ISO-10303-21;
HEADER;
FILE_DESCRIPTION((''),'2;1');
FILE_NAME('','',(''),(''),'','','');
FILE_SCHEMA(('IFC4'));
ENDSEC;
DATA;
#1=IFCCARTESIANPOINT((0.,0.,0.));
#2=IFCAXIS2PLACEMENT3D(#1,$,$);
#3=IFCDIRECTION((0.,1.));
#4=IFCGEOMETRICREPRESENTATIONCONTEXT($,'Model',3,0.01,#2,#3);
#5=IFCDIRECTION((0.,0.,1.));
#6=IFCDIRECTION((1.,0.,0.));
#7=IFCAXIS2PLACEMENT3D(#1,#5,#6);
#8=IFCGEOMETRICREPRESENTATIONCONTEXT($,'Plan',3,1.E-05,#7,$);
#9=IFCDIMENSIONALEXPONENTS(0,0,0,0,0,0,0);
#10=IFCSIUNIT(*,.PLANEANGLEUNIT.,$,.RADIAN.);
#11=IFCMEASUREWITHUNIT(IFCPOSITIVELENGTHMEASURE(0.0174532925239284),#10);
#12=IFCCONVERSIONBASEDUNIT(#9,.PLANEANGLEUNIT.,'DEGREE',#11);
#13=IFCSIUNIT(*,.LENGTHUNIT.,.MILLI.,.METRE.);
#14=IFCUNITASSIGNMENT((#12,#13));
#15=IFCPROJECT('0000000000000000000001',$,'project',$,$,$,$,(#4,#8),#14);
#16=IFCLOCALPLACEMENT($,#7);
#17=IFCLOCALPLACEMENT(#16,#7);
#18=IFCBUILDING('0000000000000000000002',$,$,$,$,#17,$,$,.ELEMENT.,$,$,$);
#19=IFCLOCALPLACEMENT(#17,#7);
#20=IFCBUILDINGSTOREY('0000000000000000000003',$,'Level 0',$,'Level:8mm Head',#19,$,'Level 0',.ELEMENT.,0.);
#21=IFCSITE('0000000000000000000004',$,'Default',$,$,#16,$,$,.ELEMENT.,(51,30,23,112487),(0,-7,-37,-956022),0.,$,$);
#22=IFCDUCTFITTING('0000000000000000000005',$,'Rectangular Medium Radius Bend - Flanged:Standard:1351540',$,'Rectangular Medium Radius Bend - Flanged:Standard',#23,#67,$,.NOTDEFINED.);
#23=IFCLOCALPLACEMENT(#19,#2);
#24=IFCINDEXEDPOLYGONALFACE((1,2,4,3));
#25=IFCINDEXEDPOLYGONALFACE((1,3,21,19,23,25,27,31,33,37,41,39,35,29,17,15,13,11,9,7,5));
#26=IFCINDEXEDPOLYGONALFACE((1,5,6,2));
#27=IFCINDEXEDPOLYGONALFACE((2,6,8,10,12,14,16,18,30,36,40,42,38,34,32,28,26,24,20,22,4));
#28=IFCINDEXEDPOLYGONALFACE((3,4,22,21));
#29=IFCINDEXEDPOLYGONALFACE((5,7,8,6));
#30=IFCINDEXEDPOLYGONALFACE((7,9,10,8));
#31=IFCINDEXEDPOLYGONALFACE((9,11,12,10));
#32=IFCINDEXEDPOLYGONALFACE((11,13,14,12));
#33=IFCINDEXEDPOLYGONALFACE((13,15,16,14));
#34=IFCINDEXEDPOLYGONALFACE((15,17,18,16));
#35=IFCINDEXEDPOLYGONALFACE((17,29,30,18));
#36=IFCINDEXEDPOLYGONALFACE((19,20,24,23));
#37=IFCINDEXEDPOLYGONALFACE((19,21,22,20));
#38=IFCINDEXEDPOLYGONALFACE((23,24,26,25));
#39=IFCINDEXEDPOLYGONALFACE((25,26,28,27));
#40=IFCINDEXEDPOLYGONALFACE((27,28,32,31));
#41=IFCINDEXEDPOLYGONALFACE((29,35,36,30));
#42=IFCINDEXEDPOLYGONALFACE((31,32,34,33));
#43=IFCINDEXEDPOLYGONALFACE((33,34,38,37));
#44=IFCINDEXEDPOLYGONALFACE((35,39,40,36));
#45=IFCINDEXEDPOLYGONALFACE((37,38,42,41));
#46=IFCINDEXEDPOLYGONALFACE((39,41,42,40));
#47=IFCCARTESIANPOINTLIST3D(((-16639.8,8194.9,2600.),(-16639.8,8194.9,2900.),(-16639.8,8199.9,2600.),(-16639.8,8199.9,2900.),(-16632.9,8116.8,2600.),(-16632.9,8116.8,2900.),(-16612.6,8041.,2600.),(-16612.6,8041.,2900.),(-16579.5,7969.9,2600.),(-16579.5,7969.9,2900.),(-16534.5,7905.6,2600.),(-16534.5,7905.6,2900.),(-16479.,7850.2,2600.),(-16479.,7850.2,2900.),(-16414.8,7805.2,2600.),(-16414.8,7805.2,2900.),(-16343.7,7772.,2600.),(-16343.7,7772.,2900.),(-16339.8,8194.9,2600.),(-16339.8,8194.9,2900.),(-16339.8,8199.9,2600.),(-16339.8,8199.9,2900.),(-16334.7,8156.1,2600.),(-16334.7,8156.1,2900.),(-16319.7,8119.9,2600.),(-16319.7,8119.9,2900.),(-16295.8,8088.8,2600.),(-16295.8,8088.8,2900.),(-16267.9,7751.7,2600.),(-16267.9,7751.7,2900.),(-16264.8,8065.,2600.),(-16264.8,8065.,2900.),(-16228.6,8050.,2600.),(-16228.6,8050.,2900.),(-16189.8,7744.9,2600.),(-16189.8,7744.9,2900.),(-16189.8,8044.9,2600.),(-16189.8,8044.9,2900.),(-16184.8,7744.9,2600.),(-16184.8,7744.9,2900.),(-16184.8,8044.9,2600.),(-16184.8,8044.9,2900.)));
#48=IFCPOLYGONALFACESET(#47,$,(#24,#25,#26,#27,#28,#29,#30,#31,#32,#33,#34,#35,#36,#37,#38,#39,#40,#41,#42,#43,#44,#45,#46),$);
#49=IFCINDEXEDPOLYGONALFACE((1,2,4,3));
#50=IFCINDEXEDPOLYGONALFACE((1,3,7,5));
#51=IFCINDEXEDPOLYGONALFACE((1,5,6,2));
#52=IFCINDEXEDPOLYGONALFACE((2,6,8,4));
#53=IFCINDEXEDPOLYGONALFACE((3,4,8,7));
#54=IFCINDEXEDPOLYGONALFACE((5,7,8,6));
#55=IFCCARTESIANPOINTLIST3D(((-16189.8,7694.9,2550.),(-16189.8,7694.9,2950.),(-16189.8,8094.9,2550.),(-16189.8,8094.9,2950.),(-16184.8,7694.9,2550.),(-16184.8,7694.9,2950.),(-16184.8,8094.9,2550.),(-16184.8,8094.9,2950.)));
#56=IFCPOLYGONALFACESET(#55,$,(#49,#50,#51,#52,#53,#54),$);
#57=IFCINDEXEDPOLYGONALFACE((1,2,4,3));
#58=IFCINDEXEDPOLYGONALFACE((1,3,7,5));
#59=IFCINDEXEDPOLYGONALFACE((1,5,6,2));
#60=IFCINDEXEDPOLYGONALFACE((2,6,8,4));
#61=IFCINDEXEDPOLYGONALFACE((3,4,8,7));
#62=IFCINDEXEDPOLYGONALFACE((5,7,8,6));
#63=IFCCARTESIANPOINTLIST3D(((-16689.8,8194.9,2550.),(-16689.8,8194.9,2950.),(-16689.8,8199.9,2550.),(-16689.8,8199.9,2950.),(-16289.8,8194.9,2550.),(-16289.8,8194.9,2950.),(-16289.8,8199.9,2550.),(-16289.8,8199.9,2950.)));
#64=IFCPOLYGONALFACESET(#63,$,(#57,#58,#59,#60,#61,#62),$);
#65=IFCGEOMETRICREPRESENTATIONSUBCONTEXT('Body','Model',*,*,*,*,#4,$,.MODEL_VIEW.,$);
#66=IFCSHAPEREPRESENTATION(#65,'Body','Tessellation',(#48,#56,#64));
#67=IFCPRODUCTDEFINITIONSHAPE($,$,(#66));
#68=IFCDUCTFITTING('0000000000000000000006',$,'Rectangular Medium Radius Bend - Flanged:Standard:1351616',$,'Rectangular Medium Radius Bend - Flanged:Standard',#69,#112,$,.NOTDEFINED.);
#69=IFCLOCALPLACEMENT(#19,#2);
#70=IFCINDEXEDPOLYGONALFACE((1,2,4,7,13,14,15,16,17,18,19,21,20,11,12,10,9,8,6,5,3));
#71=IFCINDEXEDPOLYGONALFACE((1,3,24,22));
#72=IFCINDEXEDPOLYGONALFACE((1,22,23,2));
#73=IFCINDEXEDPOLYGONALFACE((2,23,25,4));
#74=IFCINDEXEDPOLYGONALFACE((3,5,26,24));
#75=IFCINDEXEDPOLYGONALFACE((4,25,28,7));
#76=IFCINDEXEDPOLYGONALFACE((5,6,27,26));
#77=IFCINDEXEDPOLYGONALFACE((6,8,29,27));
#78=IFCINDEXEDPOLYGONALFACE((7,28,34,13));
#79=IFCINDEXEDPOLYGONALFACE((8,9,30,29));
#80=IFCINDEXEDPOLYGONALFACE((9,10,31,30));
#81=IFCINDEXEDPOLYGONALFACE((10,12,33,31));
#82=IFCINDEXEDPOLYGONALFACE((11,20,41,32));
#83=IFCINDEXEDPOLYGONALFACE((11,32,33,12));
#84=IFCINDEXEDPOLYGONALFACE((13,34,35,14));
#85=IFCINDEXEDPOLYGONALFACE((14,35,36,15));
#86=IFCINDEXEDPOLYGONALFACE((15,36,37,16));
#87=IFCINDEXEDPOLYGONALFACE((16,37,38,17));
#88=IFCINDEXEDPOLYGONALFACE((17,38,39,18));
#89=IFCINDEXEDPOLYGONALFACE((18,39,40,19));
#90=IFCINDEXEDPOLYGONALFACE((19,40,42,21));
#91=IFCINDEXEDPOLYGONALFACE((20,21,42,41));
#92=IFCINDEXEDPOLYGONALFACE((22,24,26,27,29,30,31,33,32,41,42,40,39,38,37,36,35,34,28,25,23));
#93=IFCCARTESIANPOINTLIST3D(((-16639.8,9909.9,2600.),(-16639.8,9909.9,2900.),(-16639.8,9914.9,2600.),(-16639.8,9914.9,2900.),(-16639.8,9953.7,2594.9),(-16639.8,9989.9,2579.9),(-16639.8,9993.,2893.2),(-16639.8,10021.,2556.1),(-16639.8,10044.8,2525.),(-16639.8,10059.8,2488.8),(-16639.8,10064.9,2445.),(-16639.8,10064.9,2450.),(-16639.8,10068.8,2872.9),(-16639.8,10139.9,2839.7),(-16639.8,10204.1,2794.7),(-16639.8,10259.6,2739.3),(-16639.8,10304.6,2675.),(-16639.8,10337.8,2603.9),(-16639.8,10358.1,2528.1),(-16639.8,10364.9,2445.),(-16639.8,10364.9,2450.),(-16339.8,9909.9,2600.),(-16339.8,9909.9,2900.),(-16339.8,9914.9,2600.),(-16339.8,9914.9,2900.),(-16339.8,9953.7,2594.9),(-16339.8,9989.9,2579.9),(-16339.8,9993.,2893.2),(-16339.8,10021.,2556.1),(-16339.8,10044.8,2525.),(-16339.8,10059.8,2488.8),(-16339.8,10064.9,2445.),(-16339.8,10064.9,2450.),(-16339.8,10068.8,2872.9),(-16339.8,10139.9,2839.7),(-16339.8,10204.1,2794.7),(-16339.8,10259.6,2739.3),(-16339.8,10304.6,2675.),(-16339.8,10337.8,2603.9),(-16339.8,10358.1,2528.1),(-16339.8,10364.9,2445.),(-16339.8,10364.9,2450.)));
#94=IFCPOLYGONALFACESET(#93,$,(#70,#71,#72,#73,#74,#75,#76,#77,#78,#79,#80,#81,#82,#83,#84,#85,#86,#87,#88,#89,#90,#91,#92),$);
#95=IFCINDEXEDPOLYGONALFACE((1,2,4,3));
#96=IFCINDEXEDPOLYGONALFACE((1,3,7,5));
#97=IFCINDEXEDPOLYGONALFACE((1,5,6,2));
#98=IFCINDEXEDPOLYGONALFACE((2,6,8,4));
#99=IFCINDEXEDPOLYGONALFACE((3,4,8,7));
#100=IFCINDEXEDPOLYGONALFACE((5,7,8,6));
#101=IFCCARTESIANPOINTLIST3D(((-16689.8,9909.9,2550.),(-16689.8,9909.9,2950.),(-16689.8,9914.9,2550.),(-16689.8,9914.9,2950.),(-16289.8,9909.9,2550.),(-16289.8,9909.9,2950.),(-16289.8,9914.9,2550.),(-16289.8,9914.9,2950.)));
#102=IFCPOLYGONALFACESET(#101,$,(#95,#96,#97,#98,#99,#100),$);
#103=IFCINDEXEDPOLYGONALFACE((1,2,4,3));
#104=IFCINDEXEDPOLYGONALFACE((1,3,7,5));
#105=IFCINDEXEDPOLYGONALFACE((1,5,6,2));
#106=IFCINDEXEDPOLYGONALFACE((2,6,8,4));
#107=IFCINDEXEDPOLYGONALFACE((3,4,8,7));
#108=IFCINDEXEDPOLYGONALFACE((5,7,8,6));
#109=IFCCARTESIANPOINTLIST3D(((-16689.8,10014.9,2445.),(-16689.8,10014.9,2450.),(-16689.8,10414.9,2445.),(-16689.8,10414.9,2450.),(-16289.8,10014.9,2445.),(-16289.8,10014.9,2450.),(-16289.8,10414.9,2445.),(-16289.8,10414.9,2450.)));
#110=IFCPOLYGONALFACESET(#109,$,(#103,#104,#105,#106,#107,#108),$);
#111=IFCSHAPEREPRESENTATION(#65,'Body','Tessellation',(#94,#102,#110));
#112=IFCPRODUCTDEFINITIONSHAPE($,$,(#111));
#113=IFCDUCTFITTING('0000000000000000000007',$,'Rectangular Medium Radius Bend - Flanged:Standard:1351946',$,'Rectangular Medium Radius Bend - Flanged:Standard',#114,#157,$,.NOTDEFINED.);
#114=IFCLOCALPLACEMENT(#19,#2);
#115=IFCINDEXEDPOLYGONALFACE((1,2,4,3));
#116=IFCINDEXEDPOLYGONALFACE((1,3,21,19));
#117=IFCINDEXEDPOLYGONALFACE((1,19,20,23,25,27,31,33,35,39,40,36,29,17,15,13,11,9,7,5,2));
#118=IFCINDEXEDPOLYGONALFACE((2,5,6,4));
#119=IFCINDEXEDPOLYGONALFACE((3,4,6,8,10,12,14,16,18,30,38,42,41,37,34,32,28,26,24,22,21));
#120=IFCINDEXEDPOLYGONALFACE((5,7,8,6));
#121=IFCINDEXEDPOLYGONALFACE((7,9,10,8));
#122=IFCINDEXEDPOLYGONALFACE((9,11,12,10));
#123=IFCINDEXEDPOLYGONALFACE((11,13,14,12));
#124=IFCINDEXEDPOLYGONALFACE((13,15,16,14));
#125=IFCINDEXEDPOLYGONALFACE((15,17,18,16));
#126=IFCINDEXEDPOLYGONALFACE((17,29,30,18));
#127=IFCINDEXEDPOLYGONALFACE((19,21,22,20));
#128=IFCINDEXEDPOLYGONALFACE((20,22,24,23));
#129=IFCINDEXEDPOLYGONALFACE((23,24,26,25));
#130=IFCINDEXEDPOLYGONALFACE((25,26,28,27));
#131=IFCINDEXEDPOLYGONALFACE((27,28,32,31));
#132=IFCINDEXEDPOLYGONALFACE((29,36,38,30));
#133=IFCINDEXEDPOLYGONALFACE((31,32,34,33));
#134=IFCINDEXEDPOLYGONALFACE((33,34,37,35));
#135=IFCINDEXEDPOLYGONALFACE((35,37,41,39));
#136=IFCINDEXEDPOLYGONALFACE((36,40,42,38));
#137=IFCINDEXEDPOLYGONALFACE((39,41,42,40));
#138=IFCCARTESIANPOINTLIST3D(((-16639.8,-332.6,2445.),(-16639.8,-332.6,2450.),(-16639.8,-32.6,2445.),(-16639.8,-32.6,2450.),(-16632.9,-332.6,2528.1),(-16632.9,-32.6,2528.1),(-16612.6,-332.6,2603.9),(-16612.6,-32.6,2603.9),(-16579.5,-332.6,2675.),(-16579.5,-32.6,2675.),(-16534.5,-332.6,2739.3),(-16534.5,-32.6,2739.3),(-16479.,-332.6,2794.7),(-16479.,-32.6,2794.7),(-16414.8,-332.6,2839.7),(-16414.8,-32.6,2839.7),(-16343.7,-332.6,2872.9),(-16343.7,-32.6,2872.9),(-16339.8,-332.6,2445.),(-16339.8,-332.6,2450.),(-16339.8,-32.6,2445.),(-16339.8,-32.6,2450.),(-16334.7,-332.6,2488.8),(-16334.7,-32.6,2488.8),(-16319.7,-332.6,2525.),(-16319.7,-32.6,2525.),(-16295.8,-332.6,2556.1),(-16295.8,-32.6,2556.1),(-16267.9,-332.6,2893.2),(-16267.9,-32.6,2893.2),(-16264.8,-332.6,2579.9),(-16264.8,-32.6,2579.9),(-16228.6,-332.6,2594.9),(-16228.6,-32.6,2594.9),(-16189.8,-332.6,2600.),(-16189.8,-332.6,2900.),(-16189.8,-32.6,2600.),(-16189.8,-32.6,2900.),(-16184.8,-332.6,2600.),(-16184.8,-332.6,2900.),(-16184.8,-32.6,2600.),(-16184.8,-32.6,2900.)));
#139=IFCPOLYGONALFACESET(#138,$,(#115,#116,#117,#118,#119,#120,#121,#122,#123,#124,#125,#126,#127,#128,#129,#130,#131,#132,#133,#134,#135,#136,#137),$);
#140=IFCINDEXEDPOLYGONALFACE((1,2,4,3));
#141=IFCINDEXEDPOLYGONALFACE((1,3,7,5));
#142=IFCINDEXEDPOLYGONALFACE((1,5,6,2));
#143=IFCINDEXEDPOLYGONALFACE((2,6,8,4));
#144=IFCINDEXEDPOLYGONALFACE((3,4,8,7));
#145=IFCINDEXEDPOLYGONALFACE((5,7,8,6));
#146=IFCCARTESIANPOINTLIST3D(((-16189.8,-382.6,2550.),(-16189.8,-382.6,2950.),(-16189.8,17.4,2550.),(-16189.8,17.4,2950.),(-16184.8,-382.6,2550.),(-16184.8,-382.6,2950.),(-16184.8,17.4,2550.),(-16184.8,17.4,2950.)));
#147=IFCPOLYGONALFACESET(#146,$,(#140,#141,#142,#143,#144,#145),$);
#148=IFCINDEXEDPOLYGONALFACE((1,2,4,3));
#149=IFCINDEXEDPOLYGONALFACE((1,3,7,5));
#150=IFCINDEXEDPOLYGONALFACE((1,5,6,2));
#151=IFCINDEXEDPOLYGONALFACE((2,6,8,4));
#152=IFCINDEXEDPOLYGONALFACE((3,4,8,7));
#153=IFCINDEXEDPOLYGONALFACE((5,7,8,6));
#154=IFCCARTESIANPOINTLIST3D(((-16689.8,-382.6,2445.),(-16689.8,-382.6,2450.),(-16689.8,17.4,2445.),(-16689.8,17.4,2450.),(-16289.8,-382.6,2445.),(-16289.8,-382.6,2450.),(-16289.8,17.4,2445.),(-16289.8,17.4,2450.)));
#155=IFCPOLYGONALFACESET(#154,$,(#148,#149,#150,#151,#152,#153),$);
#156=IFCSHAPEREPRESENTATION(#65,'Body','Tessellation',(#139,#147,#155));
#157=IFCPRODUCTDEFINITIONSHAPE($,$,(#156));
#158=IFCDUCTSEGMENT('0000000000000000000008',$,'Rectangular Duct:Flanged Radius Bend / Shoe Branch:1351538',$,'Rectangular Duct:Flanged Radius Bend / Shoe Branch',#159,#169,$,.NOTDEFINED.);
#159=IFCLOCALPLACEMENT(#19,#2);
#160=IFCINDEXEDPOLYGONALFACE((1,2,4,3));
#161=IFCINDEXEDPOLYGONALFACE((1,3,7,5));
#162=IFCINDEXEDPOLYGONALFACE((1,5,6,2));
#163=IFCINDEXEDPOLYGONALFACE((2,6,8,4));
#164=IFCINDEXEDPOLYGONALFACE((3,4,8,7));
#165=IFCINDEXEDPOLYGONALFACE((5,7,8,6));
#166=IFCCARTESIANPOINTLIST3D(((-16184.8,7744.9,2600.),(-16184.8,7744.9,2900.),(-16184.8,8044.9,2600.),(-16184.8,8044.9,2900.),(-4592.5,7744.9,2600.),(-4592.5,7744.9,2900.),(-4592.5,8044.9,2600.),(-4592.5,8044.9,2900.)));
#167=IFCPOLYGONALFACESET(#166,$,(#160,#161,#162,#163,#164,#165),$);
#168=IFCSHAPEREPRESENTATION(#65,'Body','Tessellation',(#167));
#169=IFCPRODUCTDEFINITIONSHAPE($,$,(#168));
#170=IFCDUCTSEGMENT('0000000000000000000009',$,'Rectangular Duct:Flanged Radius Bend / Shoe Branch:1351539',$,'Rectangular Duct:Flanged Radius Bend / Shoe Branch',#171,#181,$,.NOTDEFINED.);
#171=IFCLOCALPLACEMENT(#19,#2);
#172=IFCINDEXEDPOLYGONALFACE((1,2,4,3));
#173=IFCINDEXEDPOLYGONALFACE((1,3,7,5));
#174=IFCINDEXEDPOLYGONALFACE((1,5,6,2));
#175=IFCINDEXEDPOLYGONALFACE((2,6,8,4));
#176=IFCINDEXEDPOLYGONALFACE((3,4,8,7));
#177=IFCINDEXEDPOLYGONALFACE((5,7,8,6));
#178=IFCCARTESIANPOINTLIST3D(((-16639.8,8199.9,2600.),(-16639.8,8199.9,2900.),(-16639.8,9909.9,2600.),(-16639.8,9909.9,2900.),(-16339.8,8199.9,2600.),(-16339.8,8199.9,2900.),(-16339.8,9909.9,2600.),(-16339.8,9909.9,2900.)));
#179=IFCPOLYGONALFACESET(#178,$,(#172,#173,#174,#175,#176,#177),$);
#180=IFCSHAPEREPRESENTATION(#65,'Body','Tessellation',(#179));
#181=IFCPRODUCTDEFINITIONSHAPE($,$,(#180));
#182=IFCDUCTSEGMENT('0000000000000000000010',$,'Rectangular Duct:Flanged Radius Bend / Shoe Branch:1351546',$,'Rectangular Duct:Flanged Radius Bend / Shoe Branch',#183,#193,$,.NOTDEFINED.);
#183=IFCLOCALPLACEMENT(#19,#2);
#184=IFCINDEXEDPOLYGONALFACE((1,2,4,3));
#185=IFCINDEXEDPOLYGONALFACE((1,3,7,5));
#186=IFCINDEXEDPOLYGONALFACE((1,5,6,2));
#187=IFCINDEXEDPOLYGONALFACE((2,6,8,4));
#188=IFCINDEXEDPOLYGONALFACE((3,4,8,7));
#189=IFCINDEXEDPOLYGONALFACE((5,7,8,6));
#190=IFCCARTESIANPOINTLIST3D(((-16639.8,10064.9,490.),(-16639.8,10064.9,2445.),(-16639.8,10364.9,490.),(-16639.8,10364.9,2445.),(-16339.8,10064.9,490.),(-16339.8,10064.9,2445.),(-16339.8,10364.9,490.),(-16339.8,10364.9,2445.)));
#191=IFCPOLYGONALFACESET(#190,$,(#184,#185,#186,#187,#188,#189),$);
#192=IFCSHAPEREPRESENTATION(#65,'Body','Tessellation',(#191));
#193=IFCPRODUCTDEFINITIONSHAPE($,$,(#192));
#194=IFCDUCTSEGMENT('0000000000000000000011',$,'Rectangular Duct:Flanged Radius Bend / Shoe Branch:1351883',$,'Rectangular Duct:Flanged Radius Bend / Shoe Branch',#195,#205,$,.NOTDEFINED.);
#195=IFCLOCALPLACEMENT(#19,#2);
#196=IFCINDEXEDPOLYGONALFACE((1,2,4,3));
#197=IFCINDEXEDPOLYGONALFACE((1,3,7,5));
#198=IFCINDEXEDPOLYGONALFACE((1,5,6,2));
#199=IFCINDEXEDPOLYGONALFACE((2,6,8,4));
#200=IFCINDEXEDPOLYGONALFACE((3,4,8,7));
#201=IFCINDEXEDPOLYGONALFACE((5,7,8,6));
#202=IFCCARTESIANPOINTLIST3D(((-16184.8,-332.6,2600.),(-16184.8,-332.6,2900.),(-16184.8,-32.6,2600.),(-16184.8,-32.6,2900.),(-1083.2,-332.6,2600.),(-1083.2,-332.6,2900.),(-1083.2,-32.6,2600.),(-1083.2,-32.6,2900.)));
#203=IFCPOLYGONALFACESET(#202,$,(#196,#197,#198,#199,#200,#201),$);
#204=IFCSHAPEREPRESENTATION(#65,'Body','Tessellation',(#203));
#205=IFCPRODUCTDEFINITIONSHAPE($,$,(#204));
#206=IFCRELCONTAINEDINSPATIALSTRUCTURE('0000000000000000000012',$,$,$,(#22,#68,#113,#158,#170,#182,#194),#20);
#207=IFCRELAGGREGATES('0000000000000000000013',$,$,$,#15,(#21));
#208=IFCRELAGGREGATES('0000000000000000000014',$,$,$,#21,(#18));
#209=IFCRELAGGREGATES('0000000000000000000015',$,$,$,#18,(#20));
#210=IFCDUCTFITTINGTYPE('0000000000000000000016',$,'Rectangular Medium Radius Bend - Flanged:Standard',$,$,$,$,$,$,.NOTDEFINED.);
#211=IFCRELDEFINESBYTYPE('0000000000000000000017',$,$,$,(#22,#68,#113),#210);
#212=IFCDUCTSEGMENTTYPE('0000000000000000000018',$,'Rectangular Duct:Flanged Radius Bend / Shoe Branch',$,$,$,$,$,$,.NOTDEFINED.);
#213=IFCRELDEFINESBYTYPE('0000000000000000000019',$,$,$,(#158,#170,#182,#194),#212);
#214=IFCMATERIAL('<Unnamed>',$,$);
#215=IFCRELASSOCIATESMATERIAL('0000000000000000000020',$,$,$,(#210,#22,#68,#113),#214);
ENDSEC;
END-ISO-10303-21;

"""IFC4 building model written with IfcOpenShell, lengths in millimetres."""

from ifc_helpers import new_model, entity, si_unit, converted_unit, direction, frame, origin, origin_with_axes, place, context, subcontext, project, spatial, line, arc, indexed_curve, outline, extrude, source, transform, mapped, material, type_object, element, save


model = new_model("IFC4")

# Units and contexts
model_context = context("Model", 3, precision=0.01, world=origin(), true_north=direction((0.0, 1.0)))
plan_context = context("Plan", 3, precision=1e-05, world=origin_with_axes())
body_context = subcontext(model_context, "Body", "Model", "MODEL_VIEW")
ifc_project = project(units=[converted_unit("PLANEANGLEUNIT", "DEGREE", entity("IfcPositiveLengthMeasure", 0.0174532925239284), si_unit("PLANEANGLEUNIT", "RADIAN"), dimensions=[0, 0, 0, 0, 0, 0, 0]), si_unit("LENGTHUNIT", "METRE", prefix="MILLI")], contexts=[model_context, plan_context])

# Site, building, storey
site_placement = place(None, origin_with_axes())
site = spatial("IfcSite", under=ifc_project, at=site_placement, Name="Default", CompositionType="ELEMENT", RefLatitude=(51, 30, 23, 112487), RefLongitude=(0, -7, -37, -956022), RefElevation=0.0)
building_placement = place(site_placement, origin_with_axes())
building = spatial("IfcBuilding", under=site, at=building_placement, CompositionType="ELEMENT")
storey_placement = place(building_placement, origin_with_axes())
storey = spatial("IfcBuildingStorey", under=building, at=storey_placement, Name="Level 0", ObjectType="Level:8mm Head", LongName="Level 0", CompositionType="ELEMENT", Elevation=0.0)

# Duct fittings
ifc_material = material(Name="<Unnamed>")
duct_fitting_type = type_object("IfcDuctFittingType", Name="Rectangular Medium Radius Bend - Flanged:Standard", PredefinedType="NOTDEFINED", material=ifc_material)
shared_shape = source(origin(), body_context, "Body", "SweptSolid", [
    extrude(outline(indexed_curve([(-153.8, -301.2), (-148.7, -301.2), (169.4, -169.4), (301.3, 148.7), (301.3, 153.7), (1.3, 153.8), (1.3, 148.8), (-42.7, 42.7), (-148.7, -1.2), (-153.8, -1.2)], segments=[line(1, 2), arc(2, 3, 4), line(4, 5, 6, 7), arc(7, 8, 9), line(9, 10, 1)], self_intersect=False)), frame((-151.2, 151.2, -150.0)), (0.0, 0.0, 1.0), 300.0),
    extrude(outline(indexed_curve([(-2.5, -200.0), (2.5, -200.0), (2.5, 200.0), (-2.5, 200.0), (-2.5, -200.0)], self_intersect=False)), frame((0.0, 302.5, -200.0), z_axis=(0.0, 0.0, 1.0), x_axis=(0.0, 1.0, 0.0)), (0.0, 0.0, 1.0), 400.0),
    extrude(outline(indexed_curve([(-2.5, -200.0), (2.5, -200.0), (2.5, 200.0), (-2.5, 200.0), (-2.5, -200.0)], self_intersect=False)), frame((-302.5, 0.0, -200.0)), (0.0, 0.0, 1.0), 400.0),
])
for number, where, z_axis, x_axis, name in (
    (1, (-16489.8, 7894.9, 2750.0), (0.0, 0.0, 1.0), (0.0, -1.0, 0.0), "Rectangular Medium Radius Bend - Flanged:Standard:1351540"),
    (2, (-16489.8, 10214.9, 2750.0), (1.0, 0.0, 0.0), (0.0, 0.0, 1.0), "Rectangular Medium Radius Bend - Flanged:Standard:1351616"),
    (3, (-16489.8, -182.6, 2750.0), (0.0, 1.0, 0.0), (0.0, 0.0, 1.0), "Rectangular Medium Radius Bend - Flanged:Standard:1351946"),
):
    element("IfcDuctFitting", number, at=place(storey_placement, frame(where, z_axis=z_axis, x_axis=x_axis)), inside=storey, type_object=duct_fitting_type, material=ifc_material, Name=name, ObjectType="Rectangular Medium Radius Bend - Flanged:Standard", PredefinedType="NOTDEFINED", context=body_context, shape_type="MappedRepresentation", body=[
        mapped(shared_shape, transform((0.0, 0.0, 0.0), scale=1.0)),
    ])

# Duct segments
duct_segment_type_1 = type_object("IfcDuctSegmentType", Name="Rectangular Duct:Flanged Radius Bend / Shoe Branch", PredefinedType="NOTDEFINED")
duct_segment_1_placement = place(storey_placement, origin_with_axes())
element("IfcDuctSegment", 4, at=duct_segment_1_placement, inside=storey, type_object=duct_segment_type_1, Name="Rectangular Duct:Flanged Radius Bend / Shoe Branch:1351538", ObjectType="Rectangular Duct:Flanged Radius Bend / Shoe Branch", PredefinedType="NOTDEFINED", context=body_context, shape_type="SweptSolid", body=[
    extrude(outline(indexed_curve([(-5796.1, -150.0), (5796.1, -150.0), (5796.1, 150.0), (-5796.1, 150.0), (-5796.1, -150.0)], self_intersect=False)), frame((-10388.6, 7894.9, 2600.0), z_axis=(0.0, 0.0, 1.0), x_axis=(-1.0, 0.0, 0.0)), (0.0, 0.0, 1.0), 300.0),
])
duct_segment_2_placement = place(storey_placement, origin_with_axes())
element("IfcDuctSegment", 5, at=duct_segment_2_placement, inside=storey, type_object=duct_segment_type_1, Name="Rectangular Duct:Flanged Radius Bend / Shoe Branch:1351539", ObjectType="Rectangular Duct:Flanged Radius Bend / Shoe Branch", PredefinedType="NOTDEFINED", context=body_context, shape_type="SweptSolid", body=[
    extrude(outline(indexed_curve([(-855.0, -150.0), (855.0, -150.0), (855.0, 150.0), (-855.0, 150.0), (-855.0, -150.0)], self_intersect=False)), frame((-16489.8, 9054.9, 2600.0), z_axis=(0.0, 0.0, 1.0), x_axis=(0.0, -1.0, 0.0)), (0.0, 0.0, 1.0), 300.0),
])
duct_segment_3_placement = place(storey_placement, origin_with_axes())
element("IfcDuctSegment", 6, at=duct_segment_3_placement, inside=storey, type_object=duct_segment_type_1, Name="Rectangular Duct:Flanged Radius Bend / Shoe Branch:1351546", ObjectType="Rectangular Duct:Flanged Radius Bend / Shoe Branch", PredefinedType="NOTDEFINED", context=body_context, shape_type="SweptSolid", body=[
    extrude(outline(indexed_curve([(-150.0, -150.0), (150.0, -150.0), (150.0, 150.0), (-150.0, 150.0), (-150.0, -150.0)], self_intersect=False)), frame((-16489.8, 10214.9, 490.0), z_axis=(0.0, 0.0, 1.0), x_axis=(0.0, 1.0, 0.0)), (0.0, 0.0, 1.0), 1955.0),
])
duct_segment_4_placement = place(storey_placement, origin_with_axes())
element("IfcDuctSegment", 7, at=duct_segment_4_placement, inside=storey, type_object=duct_segment_type_1, Name="Rectangular Duct:Flanged Radius Bend / Shoe Branch:1351883", ObjectType="Rectangular Duct:Flanged Radius Bend / Shoe Branch", PredefinedType="NOTDEFINED", context=body_context, shape_type="SweptSolid", body=[
    extrude(outline(indexed_curve([(-7550.8, -150.0), (7550.8, -150.0), (7550.8, 150.0), (-7550.8, 150.0), (-7550.8, -150.0)], self_intersect=False)), frame((-8634.0, -182.6, 2600.0)), (0.0, 0.0, 1.0), 300.0),
])

save(model, "model.ifc")
